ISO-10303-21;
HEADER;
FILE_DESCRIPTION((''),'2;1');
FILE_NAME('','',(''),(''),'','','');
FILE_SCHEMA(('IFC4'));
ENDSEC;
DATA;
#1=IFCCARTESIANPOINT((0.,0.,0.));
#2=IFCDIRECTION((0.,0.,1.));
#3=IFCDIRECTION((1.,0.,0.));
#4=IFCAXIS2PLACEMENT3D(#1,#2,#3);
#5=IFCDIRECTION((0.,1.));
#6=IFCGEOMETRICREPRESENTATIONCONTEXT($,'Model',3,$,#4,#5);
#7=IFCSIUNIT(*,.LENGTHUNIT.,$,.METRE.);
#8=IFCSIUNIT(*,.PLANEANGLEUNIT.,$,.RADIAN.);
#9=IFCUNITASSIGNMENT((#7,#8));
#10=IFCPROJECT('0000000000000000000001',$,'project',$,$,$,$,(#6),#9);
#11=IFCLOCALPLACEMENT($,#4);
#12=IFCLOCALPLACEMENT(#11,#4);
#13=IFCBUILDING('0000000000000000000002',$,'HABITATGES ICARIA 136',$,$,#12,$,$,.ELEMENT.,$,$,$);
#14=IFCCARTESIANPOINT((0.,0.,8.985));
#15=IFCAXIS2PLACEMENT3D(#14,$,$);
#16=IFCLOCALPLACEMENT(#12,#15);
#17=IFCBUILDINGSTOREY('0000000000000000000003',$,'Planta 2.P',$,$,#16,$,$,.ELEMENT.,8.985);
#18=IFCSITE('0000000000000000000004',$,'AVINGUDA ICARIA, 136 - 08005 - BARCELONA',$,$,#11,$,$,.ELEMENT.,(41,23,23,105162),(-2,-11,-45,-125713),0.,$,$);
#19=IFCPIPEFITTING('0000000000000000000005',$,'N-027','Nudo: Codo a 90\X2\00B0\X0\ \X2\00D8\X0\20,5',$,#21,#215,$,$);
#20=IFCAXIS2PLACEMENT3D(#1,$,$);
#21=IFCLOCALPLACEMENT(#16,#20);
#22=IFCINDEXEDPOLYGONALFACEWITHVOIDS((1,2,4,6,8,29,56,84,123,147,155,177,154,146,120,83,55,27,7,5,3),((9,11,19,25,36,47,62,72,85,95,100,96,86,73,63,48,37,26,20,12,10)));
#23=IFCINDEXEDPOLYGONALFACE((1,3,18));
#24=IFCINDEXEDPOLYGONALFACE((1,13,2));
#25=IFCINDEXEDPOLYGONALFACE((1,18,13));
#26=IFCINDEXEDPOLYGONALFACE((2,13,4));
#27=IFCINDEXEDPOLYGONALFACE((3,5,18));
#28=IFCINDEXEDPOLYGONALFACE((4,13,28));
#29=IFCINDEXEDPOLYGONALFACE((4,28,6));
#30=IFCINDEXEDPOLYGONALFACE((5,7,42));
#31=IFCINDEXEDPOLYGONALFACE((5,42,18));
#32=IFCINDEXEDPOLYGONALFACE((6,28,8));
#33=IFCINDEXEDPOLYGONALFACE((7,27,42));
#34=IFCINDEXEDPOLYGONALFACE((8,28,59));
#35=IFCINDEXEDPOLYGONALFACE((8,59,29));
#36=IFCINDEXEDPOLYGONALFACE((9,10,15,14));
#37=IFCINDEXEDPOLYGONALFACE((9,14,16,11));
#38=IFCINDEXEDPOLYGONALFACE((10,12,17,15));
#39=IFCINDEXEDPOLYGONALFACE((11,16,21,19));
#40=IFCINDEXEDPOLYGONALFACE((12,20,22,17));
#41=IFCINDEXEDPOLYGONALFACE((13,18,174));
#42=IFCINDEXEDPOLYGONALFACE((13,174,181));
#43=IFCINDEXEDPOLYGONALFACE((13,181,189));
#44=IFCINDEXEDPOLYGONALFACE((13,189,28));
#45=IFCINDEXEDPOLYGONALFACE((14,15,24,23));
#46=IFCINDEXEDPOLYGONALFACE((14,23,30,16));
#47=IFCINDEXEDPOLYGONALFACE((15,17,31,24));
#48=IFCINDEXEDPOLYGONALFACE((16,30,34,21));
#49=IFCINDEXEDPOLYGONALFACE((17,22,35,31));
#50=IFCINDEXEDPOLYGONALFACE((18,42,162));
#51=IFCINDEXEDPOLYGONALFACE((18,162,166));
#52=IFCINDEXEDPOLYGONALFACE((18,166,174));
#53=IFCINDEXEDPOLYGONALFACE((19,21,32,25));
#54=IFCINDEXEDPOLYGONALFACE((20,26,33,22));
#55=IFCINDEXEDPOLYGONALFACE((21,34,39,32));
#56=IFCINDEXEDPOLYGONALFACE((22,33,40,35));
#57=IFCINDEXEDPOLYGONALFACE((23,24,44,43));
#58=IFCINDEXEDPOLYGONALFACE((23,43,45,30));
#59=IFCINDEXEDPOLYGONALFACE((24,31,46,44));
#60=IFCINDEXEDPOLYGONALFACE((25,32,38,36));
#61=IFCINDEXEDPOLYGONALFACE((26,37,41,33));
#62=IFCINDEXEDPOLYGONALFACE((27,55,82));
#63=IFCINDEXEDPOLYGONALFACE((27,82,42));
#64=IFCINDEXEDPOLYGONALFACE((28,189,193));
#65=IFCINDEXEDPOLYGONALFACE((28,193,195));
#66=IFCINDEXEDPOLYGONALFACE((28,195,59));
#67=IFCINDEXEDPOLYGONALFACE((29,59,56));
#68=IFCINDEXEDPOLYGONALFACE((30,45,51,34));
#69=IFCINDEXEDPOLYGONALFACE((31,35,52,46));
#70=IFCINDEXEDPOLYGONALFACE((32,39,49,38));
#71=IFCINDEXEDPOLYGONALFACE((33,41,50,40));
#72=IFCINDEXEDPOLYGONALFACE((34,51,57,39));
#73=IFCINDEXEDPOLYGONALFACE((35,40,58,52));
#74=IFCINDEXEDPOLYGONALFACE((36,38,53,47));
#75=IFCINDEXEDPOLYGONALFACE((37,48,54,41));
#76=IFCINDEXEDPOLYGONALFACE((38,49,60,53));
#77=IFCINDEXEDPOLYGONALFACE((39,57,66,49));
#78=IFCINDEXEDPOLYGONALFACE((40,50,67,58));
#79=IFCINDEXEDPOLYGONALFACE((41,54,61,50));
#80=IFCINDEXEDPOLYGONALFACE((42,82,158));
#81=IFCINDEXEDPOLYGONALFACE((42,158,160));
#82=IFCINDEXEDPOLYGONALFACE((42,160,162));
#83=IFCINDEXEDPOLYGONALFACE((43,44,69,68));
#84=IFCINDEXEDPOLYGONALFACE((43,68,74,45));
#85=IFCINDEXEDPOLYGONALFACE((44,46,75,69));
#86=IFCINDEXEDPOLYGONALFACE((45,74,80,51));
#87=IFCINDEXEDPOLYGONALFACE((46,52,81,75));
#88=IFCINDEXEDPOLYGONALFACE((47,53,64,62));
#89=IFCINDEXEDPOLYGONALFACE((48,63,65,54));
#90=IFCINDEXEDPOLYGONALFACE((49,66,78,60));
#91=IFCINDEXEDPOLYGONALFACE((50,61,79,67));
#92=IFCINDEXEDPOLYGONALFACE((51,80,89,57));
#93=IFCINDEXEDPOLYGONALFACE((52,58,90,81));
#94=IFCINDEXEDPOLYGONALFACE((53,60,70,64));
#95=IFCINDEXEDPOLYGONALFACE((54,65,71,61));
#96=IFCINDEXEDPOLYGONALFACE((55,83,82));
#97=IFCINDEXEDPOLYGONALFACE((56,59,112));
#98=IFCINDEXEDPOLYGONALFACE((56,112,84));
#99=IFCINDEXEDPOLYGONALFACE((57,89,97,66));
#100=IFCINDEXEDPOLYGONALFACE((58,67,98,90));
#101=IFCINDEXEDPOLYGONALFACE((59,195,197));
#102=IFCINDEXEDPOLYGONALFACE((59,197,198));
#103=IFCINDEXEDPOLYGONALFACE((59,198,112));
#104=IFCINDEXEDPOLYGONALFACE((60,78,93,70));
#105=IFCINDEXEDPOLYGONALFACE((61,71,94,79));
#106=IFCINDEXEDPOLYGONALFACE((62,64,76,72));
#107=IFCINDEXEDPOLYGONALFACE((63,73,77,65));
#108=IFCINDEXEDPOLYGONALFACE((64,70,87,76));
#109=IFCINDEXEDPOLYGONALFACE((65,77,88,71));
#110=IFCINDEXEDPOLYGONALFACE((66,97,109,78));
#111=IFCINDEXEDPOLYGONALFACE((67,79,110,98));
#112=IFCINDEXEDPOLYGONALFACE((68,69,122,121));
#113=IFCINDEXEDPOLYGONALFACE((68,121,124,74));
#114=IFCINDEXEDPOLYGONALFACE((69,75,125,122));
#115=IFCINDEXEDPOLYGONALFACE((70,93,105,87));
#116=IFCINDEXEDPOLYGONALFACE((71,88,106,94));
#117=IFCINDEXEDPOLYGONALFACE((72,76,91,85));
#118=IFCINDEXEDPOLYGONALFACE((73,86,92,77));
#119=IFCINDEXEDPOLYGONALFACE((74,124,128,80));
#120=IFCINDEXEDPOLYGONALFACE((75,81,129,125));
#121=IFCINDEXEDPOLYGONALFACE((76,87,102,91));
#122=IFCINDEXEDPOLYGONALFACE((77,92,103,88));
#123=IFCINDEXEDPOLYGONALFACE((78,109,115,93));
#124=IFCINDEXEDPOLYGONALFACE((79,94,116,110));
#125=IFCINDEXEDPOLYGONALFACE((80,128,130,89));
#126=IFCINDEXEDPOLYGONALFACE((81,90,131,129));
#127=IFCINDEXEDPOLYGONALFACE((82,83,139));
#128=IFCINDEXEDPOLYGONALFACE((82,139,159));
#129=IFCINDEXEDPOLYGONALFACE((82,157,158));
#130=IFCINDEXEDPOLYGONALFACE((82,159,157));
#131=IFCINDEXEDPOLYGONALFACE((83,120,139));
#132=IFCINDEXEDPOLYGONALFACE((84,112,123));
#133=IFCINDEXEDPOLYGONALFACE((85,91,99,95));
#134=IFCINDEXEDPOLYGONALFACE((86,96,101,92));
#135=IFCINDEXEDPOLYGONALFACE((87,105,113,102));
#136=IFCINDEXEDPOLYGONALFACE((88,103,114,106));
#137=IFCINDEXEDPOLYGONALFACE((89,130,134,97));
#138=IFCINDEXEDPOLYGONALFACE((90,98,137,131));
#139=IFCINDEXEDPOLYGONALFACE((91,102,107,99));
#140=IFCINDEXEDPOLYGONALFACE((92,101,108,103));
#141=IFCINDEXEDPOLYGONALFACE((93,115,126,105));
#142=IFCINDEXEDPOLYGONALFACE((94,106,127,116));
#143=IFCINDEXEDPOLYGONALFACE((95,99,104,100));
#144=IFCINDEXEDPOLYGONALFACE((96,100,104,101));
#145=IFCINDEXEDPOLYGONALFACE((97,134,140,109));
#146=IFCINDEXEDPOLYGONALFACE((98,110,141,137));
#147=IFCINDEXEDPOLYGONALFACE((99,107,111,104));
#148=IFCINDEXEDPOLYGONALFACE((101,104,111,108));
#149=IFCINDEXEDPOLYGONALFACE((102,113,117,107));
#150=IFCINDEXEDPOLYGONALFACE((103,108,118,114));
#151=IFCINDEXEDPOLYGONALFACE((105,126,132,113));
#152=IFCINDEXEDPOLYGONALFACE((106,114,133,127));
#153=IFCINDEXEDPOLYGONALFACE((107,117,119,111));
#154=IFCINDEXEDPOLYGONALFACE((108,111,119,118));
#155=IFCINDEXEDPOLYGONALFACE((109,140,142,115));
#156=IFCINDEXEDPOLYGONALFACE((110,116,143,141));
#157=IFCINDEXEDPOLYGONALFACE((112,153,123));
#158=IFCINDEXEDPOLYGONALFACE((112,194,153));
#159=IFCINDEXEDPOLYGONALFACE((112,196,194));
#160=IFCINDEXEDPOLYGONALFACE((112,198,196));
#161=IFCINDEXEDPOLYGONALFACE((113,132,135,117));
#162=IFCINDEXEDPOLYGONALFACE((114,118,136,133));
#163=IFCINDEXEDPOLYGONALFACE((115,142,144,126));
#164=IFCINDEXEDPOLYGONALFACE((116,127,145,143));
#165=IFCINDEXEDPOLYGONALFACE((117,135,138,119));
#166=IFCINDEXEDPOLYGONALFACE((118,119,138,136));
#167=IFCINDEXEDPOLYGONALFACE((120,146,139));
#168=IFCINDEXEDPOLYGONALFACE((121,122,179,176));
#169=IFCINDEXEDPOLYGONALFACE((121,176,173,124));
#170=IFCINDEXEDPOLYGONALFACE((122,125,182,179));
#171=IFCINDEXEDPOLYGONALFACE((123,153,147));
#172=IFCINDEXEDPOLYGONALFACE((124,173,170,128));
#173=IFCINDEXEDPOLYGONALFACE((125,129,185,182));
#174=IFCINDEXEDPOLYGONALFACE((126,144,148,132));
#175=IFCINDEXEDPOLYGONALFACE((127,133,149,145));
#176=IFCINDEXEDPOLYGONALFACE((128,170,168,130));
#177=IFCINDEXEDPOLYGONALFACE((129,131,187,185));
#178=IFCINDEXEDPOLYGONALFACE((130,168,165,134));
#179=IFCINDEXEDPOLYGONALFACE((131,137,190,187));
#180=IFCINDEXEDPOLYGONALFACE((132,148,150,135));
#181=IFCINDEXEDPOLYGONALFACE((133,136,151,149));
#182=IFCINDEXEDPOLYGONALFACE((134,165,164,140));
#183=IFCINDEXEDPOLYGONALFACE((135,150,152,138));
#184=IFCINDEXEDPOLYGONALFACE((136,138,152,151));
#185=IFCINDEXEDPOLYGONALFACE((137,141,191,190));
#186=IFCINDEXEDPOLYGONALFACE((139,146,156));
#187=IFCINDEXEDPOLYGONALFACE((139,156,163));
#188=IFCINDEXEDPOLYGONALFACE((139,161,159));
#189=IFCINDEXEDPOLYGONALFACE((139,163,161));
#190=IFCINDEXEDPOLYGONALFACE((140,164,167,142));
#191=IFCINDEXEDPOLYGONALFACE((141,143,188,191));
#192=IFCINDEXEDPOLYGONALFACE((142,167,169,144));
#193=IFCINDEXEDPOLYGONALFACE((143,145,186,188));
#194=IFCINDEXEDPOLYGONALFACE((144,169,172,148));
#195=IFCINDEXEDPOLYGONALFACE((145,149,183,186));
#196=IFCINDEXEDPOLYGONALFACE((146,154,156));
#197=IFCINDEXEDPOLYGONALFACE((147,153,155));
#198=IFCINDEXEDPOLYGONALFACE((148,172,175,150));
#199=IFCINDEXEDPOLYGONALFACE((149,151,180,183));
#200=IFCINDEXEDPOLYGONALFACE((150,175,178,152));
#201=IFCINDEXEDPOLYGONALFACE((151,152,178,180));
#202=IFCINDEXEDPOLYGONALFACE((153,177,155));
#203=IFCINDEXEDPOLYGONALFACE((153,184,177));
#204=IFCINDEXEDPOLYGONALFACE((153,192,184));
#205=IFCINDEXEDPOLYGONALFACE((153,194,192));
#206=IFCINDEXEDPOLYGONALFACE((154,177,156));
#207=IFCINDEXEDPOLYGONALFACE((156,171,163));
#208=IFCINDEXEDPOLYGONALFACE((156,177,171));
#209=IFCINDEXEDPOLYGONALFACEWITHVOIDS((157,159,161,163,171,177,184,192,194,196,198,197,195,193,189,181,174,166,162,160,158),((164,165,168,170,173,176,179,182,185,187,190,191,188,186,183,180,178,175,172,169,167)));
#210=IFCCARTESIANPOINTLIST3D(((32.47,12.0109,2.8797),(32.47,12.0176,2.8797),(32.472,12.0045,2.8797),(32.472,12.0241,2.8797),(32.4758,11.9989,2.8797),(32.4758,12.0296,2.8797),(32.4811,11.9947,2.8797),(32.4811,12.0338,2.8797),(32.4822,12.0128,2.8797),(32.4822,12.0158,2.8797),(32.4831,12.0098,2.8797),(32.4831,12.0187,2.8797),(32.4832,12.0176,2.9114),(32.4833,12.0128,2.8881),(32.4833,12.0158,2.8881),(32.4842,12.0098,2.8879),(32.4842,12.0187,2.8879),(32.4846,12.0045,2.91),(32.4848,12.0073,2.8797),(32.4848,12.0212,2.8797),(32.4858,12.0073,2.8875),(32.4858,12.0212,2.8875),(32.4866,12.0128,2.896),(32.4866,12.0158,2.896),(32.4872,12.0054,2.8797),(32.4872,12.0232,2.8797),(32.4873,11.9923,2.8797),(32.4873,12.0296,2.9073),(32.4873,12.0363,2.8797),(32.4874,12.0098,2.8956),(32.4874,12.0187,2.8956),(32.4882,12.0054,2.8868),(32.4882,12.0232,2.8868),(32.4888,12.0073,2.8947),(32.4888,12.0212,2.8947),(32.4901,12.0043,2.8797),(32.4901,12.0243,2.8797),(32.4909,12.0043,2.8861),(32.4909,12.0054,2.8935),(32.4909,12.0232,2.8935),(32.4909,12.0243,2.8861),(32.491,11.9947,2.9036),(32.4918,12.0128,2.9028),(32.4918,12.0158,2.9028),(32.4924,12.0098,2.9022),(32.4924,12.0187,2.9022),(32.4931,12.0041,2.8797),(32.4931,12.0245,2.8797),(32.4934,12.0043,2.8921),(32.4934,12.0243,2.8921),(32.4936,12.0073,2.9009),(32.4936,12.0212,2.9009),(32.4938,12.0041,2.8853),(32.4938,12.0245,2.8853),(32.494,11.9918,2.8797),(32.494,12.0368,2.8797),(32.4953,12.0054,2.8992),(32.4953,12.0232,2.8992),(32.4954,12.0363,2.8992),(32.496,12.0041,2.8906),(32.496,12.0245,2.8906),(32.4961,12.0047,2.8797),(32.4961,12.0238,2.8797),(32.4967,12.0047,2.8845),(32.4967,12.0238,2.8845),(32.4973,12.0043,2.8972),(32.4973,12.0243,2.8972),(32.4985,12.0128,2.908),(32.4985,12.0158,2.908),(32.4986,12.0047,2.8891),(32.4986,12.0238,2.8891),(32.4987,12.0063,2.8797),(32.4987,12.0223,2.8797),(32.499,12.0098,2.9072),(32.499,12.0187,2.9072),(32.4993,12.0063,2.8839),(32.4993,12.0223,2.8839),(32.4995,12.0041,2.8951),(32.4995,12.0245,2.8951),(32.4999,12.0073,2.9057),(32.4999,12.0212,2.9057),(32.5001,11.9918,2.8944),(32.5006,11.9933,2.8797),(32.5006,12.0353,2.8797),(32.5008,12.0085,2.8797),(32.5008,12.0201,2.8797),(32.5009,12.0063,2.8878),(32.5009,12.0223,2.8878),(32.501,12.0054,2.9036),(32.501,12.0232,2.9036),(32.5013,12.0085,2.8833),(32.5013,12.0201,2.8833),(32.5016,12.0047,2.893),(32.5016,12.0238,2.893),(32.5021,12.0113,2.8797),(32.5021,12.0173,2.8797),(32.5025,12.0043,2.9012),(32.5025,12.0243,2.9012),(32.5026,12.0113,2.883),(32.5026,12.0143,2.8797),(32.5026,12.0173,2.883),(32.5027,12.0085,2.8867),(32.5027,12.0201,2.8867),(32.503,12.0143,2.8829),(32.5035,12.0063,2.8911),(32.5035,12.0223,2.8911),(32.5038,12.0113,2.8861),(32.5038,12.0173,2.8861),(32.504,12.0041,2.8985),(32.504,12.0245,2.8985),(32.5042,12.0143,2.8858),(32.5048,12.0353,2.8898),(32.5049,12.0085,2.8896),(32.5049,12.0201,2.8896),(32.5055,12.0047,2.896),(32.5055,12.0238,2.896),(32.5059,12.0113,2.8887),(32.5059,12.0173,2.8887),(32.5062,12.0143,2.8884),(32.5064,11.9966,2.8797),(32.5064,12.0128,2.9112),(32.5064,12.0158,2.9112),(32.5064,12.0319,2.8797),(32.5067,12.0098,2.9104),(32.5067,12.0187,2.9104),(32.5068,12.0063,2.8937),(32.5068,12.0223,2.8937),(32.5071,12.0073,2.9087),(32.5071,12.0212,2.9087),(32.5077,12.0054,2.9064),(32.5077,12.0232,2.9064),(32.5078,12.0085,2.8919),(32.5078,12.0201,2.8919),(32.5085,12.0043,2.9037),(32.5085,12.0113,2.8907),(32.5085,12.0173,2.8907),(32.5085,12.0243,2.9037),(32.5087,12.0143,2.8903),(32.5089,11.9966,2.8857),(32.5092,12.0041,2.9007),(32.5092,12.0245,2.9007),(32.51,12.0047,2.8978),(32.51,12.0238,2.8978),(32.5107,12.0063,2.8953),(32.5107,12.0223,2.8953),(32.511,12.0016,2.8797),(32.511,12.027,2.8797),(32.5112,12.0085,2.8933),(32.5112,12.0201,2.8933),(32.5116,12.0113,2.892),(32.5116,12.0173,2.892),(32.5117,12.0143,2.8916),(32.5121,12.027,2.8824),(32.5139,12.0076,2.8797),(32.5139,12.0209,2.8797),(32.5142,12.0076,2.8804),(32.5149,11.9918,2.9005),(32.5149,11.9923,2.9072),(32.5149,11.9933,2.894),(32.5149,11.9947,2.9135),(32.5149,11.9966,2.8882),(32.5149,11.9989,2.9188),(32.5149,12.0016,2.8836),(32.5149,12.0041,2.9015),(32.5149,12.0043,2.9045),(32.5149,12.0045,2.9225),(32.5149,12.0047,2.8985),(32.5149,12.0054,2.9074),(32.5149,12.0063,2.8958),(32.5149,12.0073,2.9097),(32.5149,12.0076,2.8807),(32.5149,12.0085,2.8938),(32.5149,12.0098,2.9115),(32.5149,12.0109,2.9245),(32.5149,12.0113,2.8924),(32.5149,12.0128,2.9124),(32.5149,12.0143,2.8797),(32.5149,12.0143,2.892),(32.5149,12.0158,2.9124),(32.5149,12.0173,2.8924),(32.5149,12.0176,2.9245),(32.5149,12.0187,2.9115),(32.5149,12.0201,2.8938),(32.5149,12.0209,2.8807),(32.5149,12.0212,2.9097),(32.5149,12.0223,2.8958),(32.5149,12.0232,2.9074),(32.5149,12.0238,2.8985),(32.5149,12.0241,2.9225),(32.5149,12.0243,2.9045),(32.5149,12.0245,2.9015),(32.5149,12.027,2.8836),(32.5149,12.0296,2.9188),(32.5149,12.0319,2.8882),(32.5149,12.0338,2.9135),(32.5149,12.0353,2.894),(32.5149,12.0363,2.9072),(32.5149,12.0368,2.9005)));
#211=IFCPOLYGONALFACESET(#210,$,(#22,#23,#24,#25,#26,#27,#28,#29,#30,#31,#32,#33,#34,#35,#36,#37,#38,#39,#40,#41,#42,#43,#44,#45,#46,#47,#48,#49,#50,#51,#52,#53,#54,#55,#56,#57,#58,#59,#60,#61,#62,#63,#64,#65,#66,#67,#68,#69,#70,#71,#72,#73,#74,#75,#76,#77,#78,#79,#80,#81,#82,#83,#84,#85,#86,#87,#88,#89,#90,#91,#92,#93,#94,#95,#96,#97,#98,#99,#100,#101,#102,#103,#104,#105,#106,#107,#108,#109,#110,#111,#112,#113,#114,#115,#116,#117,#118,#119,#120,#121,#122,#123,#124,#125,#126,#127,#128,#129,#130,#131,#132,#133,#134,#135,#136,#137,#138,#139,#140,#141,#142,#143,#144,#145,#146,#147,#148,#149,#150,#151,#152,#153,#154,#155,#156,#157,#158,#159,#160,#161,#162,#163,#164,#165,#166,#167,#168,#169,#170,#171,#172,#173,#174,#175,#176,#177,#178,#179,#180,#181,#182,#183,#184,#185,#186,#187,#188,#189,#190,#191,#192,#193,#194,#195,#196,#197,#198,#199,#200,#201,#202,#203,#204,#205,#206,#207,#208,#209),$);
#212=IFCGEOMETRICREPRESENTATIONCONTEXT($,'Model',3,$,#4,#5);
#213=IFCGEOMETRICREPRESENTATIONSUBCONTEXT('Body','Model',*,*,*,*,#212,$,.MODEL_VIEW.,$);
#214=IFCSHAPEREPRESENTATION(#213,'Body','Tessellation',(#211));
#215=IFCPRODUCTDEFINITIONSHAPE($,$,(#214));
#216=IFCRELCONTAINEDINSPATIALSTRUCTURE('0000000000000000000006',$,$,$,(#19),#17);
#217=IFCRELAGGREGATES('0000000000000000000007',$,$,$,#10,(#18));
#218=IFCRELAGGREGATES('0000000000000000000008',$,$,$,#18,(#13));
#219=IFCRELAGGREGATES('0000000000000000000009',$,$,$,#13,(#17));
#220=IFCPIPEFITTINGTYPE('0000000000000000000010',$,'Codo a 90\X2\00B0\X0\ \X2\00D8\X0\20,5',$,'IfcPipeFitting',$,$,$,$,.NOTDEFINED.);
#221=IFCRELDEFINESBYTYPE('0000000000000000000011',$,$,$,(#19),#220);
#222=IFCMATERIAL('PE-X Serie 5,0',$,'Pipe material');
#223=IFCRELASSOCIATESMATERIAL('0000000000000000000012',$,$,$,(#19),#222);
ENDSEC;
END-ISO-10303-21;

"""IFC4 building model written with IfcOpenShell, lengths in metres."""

from ifc_helpers import new_model, entity, si_unit, direction, frame, origin_with_axes, place, context, subcontext, project, spatial, source, transform, mapped, material, type_object, element, save


model = new_model("IFC4")

# Units and contexts
model_context_1 = context("Model", 3, world=origin_with_axes(), true_north=direction((0.0, 1.0)))
model_context_2 = context("Model", 3, world=origin_with_axes(), true_north=direction((0.0, 1.0)))
body_context_1 = subcontext(model_context_2, "Body", "Model", "MODEL_VIEW")
ifc_project = project(units=[si_unit("LENGTHUNIT", "METRE"), si_unit("PLANEANGLEUNIT", "RADIAN")], contexts=[model_context_1])

# Site, building, storey
site_placement = place(None, origin_with_axes())
site = spatial("IfcSite", under=ifc_project, at=site_placement, Name="AVINGUDA ICARIA, 136 - 08005 - BARCELONA", CompositionType="ELEMENT", RefLatitude=(41, 23, 23, 105162), RefLongitude=(-2, -11, -45, -125713), RefElevation=0.0)
building_placement = place(site_placement, origin_with_axes())
building = spatial("IfcBuilding", under=site, at=building_placement, Name="HABITATGES ICARIA 136", CompositionType="ELEMENT")
storey_placement = place(building_placement, frame((0.0, 0.0, 8.985)))
storey = spatial("IfcBuildingStorey", under=building, at=storey_placement, Name="Planta 2.P", CompositionType="ELEMENT", Elevation=8.985)

# Shared definitions
ifc_material_1 = material(Name="PE-X Serie 5,0", Category="Pipe material")
placement_1 = place(None, origin_with_axes())
placement_2 = place(placement_1, origin_with_axes())
placement_3 = place(placement_2, frame((0.0, 0.0, 8.985)))

# Pipe fitting
pipe_fitting_type_1 = type_object("IfcPipeFittingType", Name="Codo a 90° Ø20,5", ApplicableOccurrence="IfcPipeFitting", PredefinedType="NOTDEFINED")
shared_shape_1 = source(origin_with_axes(), body_context_1, "Body", "SweptSolid", [
    entity("IfcRevolvedAreaSolid", entity("IfcCircleHollowProfileDef", "AREA", None, entity("IfcAxis2Placement2D", entity("IfcCartesianPoint", [0.0, 0.0]), entity("IfcDirection", [1.0, 0.0])), 0.0226, 0.0123), entity("IfcAxis2Placement3D", entity("IfcCartesianPoint", [0.0226, 0.0, 0.0]), entity("IfcDirection", [-1.0, 0.0, 0.0]), entity("IfcDirection", [0.0, -1.0, 0.0])), entity("IfcAxis1Placement", entity("IfcCartesianPoint", [0.0226, 0.0, 0.0]), entity("IfcDirection", [0.0, 1.0, 0.0])), 1.570796),
])
pipe_fitting_1_placement = place(placement_3, origin_with_axes())
element("IfcPipeFitting", 1, at=pipe_fitting_1_placement, inside=storey, type_object=pipe_fitting_type_1, material=ifc_material_1, Name="N-027", Description="Nudo: Codo a 90° Ø20,5", context=body_context_1, shape_type="MappedRepresentation", body=[
    mapped(shared_shape_1, transform((32.4923, 12.0143, 2.9022), x_axis=(0.0, 0.0, -1.0), y_axis=(-1.0, 0.0, 0.0), z_axis=(0.0, 1.0, 0.0), scale=1.0)),
])

save(model, "model.ifc")
